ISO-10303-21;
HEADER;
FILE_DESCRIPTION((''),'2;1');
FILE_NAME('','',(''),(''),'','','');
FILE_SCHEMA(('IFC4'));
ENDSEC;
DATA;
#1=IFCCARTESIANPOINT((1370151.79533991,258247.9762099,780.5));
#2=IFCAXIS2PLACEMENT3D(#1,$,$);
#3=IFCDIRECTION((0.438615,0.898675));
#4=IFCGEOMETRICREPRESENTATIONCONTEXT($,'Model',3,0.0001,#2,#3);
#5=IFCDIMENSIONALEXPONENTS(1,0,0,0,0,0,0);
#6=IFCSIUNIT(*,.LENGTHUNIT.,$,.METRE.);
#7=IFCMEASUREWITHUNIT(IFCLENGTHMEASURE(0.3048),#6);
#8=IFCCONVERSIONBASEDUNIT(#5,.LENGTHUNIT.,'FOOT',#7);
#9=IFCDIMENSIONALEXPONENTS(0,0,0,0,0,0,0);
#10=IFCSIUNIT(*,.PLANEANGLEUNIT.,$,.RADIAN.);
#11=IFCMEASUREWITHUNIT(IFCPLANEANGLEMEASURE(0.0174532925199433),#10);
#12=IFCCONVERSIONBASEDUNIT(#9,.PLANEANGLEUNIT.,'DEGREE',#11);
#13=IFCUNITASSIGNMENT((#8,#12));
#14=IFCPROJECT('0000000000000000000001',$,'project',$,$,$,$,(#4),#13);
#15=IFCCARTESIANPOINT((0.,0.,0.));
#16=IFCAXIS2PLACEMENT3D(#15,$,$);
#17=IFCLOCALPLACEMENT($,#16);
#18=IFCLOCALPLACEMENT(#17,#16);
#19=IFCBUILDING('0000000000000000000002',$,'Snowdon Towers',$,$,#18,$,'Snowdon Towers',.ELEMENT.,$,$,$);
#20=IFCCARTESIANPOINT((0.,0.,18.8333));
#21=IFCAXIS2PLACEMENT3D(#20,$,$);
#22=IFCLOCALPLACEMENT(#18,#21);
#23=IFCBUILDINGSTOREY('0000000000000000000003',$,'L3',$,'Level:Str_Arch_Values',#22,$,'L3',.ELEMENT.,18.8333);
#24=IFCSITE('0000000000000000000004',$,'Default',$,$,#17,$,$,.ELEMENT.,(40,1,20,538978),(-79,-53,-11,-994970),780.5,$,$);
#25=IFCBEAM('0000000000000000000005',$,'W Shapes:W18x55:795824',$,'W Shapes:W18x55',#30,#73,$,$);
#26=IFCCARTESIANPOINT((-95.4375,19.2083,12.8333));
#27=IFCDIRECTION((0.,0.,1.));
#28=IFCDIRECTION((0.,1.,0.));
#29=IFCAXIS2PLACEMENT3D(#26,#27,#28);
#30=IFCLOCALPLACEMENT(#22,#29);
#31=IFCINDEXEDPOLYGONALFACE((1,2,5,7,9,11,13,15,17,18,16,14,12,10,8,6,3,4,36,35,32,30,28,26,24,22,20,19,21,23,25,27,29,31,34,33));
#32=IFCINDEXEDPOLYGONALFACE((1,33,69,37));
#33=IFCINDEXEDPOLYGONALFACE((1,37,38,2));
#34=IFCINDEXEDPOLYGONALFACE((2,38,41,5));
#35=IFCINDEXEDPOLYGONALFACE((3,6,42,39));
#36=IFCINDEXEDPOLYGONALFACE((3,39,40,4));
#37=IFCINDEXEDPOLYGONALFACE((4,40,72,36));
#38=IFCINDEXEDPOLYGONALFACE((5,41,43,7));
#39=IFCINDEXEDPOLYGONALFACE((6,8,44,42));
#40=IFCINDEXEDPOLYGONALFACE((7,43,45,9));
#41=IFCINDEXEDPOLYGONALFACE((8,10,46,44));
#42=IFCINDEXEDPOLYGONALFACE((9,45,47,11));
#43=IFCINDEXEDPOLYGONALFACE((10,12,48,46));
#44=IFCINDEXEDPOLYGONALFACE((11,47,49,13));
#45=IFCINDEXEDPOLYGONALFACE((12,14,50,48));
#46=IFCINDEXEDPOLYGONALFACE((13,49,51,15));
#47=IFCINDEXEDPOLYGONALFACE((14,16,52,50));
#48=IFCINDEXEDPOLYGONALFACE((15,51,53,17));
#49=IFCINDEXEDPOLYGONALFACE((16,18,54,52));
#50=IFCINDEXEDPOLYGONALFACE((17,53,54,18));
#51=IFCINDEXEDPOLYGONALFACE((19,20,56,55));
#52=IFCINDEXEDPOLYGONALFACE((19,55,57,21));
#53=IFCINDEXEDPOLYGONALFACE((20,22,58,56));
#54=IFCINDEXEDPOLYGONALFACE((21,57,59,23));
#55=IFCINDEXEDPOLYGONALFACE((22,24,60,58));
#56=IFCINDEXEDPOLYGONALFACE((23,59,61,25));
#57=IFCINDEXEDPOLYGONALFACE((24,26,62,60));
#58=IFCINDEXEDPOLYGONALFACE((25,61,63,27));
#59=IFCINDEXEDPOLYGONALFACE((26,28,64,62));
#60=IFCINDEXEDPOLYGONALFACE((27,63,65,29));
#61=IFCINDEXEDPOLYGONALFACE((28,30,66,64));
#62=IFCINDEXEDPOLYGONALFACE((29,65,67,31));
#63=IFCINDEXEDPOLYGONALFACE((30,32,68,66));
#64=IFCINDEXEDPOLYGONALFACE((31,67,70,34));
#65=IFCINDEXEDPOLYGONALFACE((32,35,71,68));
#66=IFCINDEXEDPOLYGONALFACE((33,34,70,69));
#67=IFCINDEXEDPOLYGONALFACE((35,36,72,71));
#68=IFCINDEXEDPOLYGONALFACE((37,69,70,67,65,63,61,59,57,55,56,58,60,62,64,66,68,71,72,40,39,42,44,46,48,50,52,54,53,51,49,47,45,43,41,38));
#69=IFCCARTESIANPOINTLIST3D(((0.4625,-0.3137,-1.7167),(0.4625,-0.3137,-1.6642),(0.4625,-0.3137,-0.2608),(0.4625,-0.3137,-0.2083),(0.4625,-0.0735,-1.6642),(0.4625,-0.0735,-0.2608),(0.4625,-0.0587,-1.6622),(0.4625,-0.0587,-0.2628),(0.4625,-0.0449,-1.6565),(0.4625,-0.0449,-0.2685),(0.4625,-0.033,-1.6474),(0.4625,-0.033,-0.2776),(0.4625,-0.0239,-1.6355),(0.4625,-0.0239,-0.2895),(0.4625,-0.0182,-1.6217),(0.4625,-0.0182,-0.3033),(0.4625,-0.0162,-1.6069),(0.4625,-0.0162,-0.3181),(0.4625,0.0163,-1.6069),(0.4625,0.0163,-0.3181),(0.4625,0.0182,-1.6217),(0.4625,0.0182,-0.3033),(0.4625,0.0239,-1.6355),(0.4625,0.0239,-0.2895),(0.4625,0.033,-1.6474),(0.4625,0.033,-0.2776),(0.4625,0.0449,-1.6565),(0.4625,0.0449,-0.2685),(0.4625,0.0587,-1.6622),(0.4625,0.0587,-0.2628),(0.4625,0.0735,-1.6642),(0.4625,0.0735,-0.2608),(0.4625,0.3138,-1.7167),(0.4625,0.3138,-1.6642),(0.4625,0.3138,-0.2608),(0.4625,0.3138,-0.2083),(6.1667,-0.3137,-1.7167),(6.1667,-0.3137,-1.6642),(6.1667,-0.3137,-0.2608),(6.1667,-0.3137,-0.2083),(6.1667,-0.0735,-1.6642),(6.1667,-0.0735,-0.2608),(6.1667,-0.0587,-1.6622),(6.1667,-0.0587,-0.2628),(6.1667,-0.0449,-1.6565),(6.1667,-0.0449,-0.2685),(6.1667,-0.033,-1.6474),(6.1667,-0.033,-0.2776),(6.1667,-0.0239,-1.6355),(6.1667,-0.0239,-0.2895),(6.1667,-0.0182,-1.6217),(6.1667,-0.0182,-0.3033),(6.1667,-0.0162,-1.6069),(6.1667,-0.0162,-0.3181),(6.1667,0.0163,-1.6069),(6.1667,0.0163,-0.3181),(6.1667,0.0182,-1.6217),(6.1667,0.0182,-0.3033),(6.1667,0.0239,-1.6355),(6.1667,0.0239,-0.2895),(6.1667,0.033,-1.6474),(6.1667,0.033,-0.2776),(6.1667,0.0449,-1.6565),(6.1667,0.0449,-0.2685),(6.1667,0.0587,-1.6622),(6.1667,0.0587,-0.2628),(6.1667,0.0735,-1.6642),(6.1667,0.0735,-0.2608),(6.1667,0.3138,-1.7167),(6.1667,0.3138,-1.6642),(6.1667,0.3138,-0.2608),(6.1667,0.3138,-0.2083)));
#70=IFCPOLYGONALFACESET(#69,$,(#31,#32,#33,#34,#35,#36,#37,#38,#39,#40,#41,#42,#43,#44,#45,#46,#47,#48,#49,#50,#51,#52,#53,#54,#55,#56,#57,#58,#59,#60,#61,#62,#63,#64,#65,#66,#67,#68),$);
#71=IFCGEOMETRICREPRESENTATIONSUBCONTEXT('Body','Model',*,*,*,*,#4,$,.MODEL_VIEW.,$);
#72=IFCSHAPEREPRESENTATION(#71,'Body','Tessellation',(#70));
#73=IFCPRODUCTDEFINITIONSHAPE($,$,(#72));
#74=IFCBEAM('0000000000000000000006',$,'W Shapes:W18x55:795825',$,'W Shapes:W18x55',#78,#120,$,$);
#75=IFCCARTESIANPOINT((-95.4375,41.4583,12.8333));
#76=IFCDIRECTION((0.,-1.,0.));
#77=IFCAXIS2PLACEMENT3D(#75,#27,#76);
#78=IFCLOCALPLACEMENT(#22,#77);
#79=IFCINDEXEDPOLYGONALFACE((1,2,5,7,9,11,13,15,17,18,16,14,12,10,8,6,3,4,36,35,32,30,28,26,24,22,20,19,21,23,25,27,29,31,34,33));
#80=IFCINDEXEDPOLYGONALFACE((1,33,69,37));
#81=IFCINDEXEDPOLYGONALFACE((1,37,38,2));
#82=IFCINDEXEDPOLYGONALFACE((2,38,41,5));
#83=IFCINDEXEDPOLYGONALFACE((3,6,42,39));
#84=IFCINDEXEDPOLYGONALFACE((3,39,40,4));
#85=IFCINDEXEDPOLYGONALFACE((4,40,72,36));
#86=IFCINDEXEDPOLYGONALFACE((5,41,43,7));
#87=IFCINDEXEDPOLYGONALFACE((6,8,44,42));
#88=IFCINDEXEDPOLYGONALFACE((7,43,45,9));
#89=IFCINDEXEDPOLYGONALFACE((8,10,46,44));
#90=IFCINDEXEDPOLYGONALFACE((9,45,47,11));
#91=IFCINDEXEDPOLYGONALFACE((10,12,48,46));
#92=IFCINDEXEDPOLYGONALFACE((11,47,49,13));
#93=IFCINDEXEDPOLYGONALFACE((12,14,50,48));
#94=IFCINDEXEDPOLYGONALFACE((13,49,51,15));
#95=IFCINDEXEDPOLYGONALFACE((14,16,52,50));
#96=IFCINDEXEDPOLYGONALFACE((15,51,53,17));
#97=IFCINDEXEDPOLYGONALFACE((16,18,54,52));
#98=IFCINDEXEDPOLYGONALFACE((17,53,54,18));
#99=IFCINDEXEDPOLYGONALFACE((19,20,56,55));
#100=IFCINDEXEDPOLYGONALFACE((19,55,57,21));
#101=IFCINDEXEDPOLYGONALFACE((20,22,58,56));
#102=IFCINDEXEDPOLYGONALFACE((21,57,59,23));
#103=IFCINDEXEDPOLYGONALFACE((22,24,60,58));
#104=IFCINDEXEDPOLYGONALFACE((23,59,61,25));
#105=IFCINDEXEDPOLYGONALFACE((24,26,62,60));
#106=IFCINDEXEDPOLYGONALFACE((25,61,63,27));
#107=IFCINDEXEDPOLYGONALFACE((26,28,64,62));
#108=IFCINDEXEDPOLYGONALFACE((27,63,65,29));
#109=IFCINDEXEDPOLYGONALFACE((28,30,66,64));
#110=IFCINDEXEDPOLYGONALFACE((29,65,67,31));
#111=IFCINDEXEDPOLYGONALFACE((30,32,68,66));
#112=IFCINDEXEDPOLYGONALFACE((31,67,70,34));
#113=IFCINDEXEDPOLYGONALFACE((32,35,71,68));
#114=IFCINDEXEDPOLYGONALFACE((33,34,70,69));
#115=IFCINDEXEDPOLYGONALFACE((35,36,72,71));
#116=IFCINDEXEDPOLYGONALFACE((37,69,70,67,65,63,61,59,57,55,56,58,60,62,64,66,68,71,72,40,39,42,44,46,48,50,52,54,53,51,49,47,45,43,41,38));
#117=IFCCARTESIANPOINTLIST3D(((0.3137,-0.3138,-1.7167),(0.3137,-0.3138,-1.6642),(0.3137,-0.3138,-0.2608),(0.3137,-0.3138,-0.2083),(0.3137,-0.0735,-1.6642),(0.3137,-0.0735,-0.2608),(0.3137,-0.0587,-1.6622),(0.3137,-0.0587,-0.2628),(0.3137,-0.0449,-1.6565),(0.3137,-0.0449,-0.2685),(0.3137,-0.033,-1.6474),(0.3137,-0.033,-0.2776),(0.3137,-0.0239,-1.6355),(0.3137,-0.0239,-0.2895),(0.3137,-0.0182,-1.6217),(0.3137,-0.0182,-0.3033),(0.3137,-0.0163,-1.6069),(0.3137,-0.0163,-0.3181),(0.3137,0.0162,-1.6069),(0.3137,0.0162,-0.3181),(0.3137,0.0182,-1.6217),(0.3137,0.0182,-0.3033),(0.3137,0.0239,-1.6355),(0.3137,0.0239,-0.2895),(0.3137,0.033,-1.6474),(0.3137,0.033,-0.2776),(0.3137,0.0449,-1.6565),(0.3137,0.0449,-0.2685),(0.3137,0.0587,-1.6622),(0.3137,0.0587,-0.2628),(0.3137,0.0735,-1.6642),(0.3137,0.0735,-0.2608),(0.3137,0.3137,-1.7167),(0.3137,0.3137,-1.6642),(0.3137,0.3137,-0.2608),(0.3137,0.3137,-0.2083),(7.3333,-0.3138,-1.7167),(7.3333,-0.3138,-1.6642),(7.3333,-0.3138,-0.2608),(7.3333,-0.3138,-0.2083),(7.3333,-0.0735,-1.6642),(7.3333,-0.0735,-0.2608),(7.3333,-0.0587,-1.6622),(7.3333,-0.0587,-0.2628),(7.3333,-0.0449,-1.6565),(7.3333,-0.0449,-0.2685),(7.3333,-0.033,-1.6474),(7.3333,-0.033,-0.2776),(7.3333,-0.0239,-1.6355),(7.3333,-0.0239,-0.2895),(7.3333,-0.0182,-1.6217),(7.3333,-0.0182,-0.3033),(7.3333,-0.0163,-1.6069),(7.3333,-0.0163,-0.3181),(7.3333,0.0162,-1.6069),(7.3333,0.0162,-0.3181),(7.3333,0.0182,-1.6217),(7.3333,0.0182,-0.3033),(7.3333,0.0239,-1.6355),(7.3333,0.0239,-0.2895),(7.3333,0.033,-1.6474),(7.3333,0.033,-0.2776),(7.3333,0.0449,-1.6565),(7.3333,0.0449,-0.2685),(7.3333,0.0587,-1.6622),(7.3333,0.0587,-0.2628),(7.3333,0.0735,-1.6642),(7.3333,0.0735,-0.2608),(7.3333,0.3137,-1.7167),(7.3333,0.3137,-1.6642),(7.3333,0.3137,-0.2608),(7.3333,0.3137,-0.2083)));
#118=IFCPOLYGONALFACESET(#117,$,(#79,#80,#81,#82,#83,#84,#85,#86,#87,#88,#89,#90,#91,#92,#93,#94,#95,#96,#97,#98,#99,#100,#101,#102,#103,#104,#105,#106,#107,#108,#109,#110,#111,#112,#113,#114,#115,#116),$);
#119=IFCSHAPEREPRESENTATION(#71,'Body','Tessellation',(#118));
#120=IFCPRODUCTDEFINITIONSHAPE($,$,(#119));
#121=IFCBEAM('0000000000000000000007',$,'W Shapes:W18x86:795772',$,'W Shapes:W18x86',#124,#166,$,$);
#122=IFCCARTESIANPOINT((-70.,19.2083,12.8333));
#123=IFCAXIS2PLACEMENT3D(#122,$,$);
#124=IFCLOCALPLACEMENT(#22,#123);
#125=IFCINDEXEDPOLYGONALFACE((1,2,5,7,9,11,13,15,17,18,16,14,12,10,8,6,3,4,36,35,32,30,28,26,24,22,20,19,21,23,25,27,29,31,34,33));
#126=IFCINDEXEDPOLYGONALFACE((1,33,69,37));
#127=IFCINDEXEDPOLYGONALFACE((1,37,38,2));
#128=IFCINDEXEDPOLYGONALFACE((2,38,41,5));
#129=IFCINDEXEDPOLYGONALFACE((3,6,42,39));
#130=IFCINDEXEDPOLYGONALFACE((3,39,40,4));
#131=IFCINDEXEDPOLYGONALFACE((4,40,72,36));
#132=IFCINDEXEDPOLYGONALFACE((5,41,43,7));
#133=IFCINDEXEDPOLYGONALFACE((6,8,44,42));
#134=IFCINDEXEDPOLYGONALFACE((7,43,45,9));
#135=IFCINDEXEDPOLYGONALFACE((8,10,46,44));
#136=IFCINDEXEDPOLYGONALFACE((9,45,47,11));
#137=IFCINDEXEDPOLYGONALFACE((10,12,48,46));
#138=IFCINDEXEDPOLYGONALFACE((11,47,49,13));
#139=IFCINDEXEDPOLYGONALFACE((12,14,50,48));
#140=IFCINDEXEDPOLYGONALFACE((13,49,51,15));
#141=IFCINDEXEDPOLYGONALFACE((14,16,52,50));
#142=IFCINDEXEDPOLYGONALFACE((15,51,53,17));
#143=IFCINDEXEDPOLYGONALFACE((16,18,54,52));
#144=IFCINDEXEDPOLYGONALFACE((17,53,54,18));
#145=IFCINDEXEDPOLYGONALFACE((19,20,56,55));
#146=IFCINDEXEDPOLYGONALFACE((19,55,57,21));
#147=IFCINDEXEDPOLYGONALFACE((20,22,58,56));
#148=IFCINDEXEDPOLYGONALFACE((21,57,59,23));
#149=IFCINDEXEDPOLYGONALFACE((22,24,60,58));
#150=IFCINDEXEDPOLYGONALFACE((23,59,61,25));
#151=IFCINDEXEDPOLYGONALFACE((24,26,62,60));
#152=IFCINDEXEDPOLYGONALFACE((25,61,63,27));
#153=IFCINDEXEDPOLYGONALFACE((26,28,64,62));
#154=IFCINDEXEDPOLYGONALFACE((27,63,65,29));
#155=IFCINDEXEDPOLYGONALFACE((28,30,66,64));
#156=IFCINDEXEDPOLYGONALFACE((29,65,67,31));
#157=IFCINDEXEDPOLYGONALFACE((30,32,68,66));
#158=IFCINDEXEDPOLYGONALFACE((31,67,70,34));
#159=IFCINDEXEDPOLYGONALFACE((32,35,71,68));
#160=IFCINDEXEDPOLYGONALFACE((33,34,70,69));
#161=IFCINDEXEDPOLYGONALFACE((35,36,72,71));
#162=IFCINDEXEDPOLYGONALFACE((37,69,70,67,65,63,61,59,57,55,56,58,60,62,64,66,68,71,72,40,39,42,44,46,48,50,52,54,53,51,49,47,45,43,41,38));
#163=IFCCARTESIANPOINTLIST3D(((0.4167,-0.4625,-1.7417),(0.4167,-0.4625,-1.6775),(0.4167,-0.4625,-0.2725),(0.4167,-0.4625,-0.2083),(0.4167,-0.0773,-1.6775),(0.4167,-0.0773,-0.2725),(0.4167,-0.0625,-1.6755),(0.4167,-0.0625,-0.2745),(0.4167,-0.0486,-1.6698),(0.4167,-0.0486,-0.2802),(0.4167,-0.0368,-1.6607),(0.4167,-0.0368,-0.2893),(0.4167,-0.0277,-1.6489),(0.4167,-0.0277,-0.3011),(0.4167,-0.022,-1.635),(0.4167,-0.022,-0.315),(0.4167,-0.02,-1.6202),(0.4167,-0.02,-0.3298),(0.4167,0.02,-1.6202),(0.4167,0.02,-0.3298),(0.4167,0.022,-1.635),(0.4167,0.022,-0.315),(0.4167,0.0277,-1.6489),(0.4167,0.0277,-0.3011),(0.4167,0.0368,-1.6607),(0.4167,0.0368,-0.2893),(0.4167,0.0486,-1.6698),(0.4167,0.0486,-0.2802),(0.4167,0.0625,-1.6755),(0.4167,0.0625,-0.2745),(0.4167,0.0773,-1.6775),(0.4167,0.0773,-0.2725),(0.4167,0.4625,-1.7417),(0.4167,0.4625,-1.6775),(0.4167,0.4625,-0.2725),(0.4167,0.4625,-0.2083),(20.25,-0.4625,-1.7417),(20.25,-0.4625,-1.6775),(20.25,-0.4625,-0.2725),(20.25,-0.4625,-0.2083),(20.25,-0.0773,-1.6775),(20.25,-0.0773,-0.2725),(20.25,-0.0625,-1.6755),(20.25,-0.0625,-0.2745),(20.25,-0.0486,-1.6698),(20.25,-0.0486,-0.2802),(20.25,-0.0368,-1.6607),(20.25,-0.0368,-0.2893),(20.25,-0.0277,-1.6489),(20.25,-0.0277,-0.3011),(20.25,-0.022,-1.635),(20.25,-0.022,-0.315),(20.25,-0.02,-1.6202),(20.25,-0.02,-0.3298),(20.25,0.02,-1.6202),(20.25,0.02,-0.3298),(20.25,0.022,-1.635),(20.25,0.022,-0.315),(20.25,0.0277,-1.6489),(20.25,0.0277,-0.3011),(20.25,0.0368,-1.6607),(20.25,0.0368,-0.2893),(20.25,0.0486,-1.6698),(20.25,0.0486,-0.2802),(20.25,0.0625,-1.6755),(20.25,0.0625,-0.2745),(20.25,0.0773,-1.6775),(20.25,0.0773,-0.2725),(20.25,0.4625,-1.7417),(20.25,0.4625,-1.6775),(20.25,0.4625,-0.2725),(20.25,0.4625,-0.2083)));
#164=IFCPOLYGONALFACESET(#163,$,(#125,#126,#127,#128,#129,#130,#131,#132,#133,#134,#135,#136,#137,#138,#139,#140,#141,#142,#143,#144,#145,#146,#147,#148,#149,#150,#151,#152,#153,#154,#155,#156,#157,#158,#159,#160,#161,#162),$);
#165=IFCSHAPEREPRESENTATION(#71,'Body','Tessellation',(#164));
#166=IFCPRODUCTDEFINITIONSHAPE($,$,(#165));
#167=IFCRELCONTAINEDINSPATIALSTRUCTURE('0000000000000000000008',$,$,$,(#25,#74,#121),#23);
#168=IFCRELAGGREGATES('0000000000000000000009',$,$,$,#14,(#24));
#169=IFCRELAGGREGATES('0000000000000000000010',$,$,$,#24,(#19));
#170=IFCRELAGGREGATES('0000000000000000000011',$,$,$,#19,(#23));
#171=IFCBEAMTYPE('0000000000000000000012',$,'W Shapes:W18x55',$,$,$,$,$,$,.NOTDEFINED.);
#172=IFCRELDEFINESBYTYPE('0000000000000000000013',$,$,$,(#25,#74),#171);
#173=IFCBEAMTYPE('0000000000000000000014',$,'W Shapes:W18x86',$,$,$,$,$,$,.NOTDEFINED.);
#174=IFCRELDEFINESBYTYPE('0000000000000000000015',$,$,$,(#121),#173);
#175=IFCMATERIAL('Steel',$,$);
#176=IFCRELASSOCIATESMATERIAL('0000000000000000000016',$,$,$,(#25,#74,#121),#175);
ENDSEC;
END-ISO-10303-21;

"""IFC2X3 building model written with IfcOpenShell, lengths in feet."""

from ifc_helpers import new_model, entity, si_unit, converted_unit, direction, frame, frame_2d, origin, place, context, subcontext, project, spatial, i_section, extrude, material, type_object, element, save


model = new_model("IFC2X3")

# Units and contexts
model_context = context("Model", 3, precision=0.0001, world=frame((1370151.79533991, 258247.9762099, 780.5)), true_north=direction((0.438615, 0.898675)))
body_context = subcontext(model_context, "Body", "Model", "MODEL_VIEW")
ifc_project = project(units=[converted_unit("LENGTHUNIT", "FOOT", entity("IfcLengthMeasure", 0.3048), si_unit("LENGTHUNIT", "METRE"), dimensions=[1, 0, 0, 0, 0, 0, 0]), converted_unit("PLANEANGLEUNIT", "DEGREE", entity("IfcPlaneAngleMeasure", 0.0174532925199433), si_unit("PLANEANGLEUNIT", "RADIAN"), dimensions=[0, 0, 0, 0, 0, 0, 0])], contexts=[model_context])

# Site, building, storey
site_placement = place(None, origin())
site = spatial("IfcSite", under=ifc_project, at=site_placement, Name="Default", CompositionType="ELEMENT", RefLatitude=(40, 1, 20, 538978), RefLongitude=(-79, -53, -11, -994970), RefElevation=780.5)
building_placement = place(site_placement, origin())
building = spatial("IfcBuilding", under=site, at=building_placement, Name="Snowdon Towers", LongName="Snowdon Towers", CompositionType="ELEMENT")
storey_placement = place(building_placement, frame((0.0, 0.0, 18.8333)))
storey = spatial("IfcBuildingStorey", under=building, at=storey_placement, Name="L3", ObjectType="Level:Str_Arch_Values", LongName="L3", CompositionType="ELEMENT", Elevation=18.8333)

# Shared definitions
ifc_material_1 = material(Name="Steel")

# Beams
beam_type_1 = type_object("IfcBeamType", Name="W Shapes:W18x55", PredefinedType="NOTDEFINED")
beam_1_placement = place(storey_placement, frame((-95.4375, 19.2083, 12.8333), z_axis=(0.0, 0.0, 1.0), x_axis=(0.0, 1.0, 0.0)))
element("IfcBeam", 1, at=beam_1_placement, inside=storey, type_object=beam_type_1, material=ifc_material_1, Name="W Shapes:W18x55:795824", ObjectType="W Shapes:W18x55", context=body_context, shape_type="SweptSolid", body=[
    extrude(i_section(OverallWidth=0.6275, OverallDepth=1.5083, WebThickness=0.0325, FlangeThickness=0.0525, FilletRadius=0.0573, at=frame_2d((0.0, 0.0), x_axis=(0.0, 1.0))), frame((0.4625, 0.0, -0.9625), z_axis=(1.0, 0.0, 0.0), x_axis=(0.0, 0.0, -1.0)), (0.0, 0.0, 1.0), 5.7042),
])
beam_2_placement = place(storey_placement, frame((-95.4375, 41.4583, 12.8333), z_axis=(0.0, 0.0, 1.0), x_axis=(0.0, -1.0, 0.0)))
element("IfcBeam", 2, at=beam_2_placement, inside=storey, type_object=beam_type_1, material=ifc_material_1, Name="W Shapes:W18x55:795825", ObjectType="W Shapes:W18x55", context=body_context, shape_type="SweptSolid", body=[
    extrude(i_section(OverallWidth=0.6275, OverallDepth=1.5083, WebThickness=0.0325, FlangeThickness=0.0525, FilletRadius=0.0573, at=frame_2d((0.0, 0.0), x_axis=(0.0, 1.0))), frame((0.3137, 0.0, -0.9625), z_axis=(1.0, 0.0, 0.0), x_axis=(0.0, 0.0, -1.0)), (0.0, 0.0, 1.0), 7.0196),
])
beam_type_2 = type_object("IfcBeamType", Name="W Shapes:W18x86", PredefinedType="NOTDEFINED")
beam_3_placement = place(storey_placement, frame((-70.0, 19.2083, 12.8333)))
element("IfcBeam", 3, at=beam_3_placement, inside=storey, type_object=beam_type_2, material=ifc_material_1, Name="W Shapes:W18x86:795772", ObjectType="W Shapes:W18x86", context=body_context, shape_type="SweptSolid", body=[
    extrude(i_section(OverallWidth=0.925, OverallDepth=1.5333, WebThickness=0.04, FlangeThickness=0.0642, FilletRadius=0.0573, at=frame_2d((0.0, 0.0), x_axis=(0.0, 1.0))), frame((0.4167, 0.0, -0.975), z_axis=(1.0, 0.0, 0.0), x_axis=(0.0, 0.0, -1.0)), (0.0, 0.0, 1.0), 19.8333),
])

save(model, "model.ifc")
